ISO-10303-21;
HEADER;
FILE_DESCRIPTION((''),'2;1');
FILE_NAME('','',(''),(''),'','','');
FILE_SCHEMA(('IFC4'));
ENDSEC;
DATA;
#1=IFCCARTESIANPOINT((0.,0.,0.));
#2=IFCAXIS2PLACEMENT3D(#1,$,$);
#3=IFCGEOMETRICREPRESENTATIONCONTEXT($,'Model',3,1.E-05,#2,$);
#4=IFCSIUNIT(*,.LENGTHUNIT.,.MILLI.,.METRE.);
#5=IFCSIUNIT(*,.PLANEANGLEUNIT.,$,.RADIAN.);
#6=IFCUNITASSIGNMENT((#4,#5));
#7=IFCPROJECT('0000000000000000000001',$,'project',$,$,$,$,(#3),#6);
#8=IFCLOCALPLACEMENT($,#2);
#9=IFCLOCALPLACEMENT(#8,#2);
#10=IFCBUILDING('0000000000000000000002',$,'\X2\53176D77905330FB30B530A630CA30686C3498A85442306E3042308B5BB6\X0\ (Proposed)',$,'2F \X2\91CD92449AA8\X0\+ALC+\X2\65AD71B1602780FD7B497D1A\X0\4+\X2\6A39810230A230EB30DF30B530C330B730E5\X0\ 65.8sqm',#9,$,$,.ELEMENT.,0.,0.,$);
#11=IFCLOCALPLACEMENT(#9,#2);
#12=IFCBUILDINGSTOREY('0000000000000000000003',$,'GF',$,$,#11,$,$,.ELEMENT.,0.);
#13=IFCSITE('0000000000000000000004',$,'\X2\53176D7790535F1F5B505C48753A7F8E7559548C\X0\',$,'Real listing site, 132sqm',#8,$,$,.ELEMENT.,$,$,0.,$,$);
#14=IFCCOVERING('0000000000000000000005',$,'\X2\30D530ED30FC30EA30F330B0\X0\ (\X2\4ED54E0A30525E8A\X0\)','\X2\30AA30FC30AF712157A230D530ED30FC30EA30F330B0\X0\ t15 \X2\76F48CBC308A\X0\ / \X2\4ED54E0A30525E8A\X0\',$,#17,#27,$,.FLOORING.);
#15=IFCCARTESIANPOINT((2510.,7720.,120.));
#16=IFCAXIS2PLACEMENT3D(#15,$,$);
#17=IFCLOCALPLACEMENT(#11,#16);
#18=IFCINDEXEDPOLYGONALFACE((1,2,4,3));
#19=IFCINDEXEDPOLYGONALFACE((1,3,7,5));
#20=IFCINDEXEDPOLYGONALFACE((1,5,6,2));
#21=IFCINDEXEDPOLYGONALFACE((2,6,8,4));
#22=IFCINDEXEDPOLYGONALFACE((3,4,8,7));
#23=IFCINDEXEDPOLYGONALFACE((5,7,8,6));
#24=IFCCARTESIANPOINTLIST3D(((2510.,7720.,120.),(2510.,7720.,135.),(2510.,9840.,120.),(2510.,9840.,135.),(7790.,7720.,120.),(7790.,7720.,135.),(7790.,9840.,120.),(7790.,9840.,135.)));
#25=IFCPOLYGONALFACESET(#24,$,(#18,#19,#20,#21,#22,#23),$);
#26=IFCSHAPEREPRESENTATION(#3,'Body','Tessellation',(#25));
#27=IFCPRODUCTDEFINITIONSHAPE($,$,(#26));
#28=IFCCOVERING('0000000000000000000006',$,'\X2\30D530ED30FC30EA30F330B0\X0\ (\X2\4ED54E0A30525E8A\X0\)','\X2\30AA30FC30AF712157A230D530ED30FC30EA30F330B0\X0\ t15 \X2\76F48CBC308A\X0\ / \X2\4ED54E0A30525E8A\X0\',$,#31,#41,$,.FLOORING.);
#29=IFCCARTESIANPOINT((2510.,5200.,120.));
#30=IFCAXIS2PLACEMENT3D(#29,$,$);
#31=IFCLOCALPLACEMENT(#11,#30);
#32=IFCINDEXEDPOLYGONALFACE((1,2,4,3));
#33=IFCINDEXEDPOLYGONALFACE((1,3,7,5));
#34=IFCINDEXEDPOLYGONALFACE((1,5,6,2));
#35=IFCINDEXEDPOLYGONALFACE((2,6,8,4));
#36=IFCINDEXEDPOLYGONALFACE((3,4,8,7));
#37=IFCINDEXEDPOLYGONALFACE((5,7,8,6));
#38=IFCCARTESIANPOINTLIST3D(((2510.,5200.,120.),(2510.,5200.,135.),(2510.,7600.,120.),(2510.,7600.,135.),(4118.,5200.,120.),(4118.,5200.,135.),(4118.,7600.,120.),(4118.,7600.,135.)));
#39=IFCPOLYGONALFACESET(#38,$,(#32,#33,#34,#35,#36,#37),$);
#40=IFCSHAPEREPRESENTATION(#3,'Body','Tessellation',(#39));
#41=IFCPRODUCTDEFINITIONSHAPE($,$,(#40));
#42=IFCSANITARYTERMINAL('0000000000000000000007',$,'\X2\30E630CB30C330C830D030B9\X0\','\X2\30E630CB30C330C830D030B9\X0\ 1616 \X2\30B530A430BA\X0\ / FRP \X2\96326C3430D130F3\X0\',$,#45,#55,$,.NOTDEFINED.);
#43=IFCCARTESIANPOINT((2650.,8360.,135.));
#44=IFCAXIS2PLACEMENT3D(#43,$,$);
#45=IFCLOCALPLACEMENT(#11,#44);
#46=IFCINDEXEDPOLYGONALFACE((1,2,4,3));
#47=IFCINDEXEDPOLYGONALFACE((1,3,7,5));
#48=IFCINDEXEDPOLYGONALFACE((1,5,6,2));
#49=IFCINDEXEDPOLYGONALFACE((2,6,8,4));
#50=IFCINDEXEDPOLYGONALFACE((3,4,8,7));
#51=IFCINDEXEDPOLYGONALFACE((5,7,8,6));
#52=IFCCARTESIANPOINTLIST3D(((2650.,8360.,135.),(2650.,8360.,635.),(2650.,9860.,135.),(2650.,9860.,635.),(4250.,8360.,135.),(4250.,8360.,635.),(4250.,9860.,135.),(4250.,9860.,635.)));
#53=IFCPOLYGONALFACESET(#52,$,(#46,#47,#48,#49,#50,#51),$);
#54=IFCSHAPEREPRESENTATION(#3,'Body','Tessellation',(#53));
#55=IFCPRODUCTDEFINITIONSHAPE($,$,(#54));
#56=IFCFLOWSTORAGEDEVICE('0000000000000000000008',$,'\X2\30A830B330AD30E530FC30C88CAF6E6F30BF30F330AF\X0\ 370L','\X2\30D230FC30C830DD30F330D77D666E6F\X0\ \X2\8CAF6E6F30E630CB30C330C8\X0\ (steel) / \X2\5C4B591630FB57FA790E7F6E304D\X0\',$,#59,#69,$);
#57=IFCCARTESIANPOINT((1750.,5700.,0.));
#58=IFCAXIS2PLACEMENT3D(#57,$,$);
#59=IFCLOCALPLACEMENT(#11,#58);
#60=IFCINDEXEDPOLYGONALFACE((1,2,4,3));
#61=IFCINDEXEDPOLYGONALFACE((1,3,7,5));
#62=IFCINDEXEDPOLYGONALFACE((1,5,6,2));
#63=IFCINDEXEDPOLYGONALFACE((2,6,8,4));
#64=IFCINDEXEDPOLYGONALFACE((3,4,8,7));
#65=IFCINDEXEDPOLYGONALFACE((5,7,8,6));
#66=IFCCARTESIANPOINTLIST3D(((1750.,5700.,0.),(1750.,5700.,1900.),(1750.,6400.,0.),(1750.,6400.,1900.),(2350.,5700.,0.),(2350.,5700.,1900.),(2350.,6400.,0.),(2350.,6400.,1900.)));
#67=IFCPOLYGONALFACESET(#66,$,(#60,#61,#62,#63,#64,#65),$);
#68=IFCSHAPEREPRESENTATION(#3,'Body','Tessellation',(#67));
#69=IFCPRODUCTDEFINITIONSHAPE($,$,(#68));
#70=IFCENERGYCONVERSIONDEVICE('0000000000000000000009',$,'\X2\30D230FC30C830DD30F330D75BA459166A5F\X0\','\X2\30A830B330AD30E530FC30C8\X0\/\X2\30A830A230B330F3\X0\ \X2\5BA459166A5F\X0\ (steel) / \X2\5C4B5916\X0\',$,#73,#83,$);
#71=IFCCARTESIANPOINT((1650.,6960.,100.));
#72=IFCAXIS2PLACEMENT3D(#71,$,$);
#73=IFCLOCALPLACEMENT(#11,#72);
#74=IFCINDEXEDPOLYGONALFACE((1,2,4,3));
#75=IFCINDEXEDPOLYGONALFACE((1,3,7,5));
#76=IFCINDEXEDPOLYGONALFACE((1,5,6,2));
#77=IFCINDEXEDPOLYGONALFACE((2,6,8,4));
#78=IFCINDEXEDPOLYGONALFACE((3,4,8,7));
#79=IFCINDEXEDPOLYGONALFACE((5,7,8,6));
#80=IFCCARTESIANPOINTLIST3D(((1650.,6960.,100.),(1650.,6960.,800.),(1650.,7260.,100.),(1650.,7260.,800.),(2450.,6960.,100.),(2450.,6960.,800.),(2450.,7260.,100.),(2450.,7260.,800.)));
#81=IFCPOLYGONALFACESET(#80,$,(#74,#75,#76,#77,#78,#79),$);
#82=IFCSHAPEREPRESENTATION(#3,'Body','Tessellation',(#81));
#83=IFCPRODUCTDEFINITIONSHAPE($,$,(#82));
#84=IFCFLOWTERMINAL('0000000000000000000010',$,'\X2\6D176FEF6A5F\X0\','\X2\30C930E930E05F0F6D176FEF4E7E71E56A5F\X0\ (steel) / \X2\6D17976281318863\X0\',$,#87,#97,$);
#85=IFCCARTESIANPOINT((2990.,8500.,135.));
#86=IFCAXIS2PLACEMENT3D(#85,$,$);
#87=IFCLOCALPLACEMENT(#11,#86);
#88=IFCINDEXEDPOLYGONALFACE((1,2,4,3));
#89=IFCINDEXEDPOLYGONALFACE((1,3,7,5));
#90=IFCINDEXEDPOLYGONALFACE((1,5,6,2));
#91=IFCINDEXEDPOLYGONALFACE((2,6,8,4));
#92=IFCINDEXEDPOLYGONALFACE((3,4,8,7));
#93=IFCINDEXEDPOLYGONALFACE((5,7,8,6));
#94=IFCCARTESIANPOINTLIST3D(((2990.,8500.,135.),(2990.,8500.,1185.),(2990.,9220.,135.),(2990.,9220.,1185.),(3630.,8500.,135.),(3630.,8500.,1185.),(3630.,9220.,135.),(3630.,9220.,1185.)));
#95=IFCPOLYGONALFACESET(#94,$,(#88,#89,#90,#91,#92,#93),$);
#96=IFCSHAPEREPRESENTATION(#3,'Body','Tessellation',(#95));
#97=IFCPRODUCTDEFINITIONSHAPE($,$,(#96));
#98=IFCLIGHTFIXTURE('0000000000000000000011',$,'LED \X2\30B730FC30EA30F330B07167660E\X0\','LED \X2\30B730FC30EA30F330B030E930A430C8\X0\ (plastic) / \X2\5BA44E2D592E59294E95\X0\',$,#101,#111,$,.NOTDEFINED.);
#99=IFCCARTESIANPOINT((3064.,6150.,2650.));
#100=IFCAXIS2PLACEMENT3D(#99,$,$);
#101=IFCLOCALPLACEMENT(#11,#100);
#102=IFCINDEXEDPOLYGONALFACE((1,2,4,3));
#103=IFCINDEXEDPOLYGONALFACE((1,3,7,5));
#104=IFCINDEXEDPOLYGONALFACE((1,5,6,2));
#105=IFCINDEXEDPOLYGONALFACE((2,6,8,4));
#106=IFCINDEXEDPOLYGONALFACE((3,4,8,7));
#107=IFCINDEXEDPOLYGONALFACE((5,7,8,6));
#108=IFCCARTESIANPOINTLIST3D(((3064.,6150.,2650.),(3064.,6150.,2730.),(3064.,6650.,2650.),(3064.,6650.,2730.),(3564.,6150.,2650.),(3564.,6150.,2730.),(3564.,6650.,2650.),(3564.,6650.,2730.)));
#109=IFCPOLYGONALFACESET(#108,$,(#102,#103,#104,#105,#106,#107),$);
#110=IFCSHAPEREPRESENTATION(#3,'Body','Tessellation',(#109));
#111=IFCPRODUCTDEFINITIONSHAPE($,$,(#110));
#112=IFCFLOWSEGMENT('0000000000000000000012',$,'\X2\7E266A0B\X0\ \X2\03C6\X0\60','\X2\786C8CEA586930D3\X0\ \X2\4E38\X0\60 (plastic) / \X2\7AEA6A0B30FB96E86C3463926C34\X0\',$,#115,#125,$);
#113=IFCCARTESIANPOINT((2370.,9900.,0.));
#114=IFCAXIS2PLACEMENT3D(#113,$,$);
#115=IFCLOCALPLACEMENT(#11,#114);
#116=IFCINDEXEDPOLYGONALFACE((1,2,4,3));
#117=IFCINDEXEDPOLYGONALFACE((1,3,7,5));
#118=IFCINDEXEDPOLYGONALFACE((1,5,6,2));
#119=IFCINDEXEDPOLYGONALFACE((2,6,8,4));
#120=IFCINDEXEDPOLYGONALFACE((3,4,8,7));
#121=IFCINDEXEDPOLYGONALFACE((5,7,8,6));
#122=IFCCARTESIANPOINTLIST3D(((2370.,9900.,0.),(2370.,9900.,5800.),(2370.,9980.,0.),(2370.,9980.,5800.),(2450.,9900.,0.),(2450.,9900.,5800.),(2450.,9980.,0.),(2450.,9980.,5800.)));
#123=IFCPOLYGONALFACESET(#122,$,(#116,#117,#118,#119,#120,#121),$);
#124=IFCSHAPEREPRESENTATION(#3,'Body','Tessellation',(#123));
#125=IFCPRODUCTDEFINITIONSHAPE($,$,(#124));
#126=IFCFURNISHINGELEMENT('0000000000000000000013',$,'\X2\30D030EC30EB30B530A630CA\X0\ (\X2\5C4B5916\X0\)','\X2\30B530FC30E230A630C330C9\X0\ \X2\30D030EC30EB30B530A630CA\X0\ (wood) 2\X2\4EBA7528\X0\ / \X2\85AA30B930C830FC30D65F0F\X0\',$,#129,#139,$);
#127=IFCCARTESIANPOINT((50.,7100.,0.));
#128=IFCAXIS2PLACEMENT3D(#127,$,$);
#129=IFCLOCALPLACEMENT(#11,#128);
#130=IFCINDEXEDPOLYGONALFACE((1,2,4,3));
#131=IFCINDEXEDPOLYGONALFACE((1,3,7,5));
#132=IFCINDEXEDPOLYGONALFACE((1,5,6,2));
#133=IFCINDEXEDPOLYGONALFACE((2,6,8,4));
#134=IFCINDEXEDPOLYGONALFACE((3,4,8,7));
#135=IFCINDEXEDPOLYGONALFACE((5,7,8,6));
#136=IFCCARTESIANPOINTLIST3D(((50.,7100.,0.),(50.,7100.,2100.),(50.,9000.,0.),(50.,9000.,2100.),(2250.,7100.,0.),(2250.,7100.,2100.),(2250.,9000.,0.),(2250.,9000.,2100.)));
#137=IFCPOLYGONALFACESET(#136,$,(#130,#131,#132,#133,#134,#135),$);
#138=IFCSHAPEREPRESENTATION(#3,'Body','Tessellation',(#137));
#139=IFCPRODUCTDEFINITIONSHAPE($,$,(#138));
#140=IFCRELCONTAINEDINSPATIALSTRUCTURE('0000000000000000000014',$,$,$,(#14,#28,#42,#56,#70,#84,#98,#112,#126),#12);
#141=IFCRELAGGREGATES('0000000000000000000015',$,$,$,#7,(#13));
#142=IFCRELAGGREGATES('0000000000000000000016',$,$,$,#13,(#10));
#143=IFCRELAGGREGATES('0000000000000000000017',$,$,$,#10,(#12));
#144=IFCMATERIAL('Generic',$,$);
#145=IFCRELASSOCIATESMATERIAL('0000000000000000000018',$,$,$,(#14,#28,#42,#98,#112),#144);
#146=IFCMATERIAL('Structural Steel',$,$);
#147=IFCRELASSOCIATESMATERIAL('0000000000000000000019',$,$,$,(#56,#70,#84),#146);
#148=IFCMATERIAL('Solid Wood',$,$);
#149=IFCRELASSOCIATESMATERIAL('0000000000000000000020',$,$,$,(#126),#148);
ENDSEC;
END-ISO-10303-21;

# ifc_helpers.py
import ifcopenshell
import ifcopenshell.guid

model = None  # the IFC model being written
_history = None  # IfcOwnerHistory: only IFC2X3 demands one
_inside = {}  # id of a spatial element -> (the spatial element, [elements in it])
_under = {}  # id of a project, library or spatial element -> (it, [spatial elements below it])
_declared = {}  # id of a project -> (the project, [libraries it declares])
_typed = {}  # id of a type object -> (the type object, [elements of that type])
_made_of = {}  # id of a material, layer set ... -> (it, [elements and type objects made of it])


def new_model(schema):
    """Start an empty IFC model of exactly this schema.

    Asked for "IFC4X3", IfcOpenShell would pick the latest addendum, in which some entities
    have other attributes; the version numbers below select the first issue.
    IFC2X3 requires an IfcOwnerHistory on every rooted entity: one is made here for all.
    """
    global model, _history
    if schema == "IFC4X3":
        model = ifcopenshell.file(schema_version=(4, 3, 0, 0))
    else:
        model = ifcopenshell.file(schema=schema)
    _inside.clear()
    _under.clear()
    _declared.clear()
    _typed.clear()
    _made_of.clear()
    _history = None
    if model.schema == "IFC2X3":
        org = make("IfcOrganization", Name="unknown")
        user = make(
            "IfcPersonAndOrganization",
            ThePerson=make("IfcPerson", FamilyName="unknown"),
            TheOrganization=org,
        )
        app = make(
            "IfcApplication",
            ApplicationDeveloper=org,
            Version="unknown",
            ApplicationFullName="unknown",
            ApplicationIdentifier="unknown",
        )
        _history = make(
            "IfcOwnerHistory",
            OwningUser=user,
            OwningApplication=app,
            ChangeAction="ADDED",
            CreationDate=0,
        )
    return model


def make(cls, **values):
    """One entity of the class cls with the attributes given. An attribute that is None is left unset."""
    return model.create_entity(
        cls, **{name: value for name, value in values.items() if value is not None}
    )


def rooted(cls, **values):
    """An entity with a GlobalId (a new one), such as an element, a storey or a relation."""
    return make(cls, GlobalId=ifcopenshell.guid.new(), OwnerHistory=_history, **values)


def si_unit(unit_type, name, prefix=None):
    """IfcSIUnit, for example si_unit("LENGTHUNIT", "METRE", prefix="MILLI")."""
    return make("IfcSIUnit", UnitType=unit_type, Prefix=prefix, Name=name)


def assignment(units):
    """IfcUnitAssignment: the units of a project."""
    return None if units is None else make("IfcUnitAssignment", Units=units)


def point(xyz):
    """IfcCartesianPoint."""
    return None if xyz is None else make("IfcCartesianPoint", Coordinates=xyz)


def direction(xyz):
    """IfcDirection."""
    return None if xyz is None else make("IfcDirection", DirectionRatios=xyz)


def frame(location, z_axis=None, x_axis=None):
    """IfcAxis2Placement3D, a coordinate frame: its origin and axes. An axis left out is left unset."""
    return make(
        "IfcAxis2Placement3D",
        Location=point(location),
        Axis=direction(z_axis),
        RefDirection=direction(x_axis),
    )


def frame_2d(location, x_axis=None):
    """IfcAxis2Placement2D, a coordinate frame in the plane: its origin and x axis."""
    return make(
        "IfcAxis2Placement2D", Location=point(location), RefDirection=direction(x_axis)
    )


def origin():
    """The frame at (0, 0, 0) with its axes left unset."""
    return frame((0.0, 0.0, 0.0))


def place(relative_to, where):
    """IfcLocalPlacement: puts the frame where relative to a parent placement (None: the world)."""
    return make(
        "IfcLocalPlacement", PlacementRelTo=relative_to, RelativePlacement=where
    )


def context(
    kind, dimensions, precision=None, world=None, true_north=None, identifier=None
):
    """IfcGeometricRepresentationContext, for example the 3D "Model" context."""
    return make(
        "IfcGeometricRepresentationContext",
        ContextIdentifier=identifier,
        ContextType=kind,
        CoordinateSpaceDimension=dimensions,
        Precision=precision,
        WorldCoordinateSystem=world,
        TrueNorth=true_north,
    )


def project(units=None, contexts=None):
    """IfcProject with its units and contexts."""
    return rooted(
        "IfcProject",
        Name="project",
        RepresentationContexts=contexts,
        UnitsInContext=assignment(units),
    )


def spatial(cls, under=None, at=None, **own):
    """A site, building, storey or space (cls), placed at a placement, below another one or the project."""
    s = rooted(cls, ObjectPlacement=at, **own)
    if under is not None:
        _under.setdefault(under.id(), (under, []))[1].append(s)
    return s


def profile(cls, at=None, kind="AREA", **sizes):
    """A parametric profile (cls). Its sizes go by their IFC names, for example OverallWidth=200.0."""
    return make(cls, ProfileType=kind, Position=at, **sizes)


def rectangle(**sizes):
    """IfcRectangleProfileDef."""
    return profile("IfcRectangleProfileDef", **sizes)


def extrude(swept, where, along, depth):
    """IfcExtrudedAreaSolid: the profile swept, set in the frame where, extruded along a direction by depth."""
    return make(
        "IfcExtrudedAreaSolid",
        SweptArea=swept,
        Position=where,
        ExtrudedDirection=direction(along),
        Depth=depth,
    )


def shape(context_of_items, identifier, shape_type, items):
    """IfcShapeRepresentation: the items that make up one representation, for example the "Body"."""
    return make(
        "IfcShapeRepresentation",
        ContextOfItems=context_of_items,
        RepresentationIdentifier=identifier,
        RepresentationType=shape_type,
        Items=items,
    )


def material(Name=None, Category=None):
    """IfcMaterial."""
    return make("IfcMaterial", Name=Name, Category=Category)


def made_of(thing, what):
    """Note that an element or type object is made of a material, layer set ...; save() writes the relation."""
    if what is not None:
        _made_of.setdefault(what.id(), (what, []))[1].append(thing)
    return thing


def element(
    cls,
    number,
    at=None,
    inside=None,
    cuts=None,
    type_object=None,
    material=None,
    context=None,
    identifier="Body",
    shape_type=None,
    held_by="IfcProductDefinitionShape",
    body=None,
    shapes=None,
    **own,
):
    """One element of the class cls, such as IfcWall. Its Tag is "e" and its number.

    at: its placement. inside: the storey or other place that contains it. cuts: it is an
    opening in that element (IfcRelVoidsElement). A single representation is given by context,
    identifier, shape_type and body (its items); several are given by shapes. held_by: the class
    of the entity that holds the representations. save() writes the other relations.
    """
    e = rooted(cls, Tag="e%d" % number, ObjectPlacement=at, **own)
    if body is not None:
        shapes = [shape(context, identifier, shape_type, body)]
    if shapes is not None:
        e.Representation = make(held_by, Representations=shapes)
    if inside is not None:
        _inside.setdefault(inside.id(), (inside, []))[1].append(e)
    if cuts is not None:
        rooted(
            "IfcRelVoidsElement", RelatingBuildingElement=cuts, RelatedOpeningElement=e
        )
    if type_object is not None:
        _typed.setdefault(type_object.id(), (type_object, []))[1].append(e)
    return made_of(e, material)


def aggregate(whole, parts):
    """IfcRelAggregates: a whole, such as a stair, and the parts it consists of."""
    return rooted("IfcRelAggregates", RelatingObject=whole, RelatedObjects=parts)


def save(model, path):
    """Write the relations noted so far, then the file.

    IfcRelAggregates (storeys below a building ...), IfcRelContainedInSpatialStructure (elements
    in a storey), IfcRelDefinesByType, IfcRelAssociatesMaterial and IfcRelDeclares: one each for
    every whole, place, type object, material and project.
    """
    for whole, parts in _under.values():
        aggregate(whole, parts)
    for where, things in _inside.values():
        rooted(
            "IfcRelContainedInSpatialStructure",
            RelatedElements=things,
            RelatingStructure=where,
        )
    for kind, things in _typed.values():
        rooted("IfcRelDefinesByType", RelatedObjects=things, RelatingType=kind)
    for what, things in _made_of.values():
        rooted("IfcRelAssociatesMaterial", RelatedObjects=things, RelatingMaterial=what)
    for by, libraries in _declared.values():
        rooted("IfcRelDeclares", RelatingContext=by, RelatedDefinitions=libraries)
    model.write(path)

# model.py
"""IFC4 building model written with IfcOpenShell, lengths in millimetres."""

from ifc_helpers import new_model, si_unit, frame, frame_2d, origin, place, context, project, spatial, rectangle, extrude, material, element, save


model = new_model("IFC4")

# Units and contexts
model_context = context("Model", 3, precision=1e-05, world=origin())
ifc_project = project(units=[si_unit("LENGTHUNIT", "METRE", prefix="MILLI"), si_unit("PLANEANGLEUNIT", "RADIAN")], contexts=[model_context])

# Site, building, storey
site_placement = place(None, origin())
site = spatial("IfcSite", under=ifc_project, at=site_placement, Name="北海道弟子屈町美留和", ObjectType="Real listing site, 132sqm", CompositionType="ELEMENT", RefElevation=0.0)
building_placement = place(site_placement, origin())
building = spatial("IfcBuilding", under=site, at=building_placement, Name="北海道・サウナと水風呂のある家 (Proposed)", ObjectType="2F 重鉄骨+ALC+断熱性能等級4+樹脂アルミサッシュ 65.8sqm", CompositionType="ELEMENT", ElevationOfRefHeight=0.0, ElevationOfTerrain=0.0)
storey_placement = place(building_placement, origin())
storey = spatial("IfcBuildingStorey", under=building, at=storey_placement, Name="GF", CompositionType="ELEMENT", Elevation=0.0)

# Shared definitions
ifc_material_1 = material(Name="Solid Wood")

# Coverings
ifc_material_2 = material(Name="Generic")
covering_1_placement = place(storey_placement, frame((2510.0, 7720.0, 120.0)))
element("IfcCovering", 1, at=covering_1_placement, inside=storey, material=ifc_material_2, Name="フローリング (仕上げ床)", Description="オーク無垢フローリング t15 直貼り / 仕上げ床", PredefinedType="FLOORING", context=model_context, shape_type="SweptSolid", body=[
    extrude(rectangle(XDim=5280.0, YDim=2120.0, at=frame_2d((2640.0, 1060.0))), frame((2510.0, 7720.0, 120.0)), (0.0, 0.0, 1.0), 15.0),
])
covering_2_placement = place(storey_placement, frame((2510.0, 5200.0, 120.0)))
element("IfcCovering", 2, at=covering_2_placement, inside=storey, material=ifc_material_2, Name="フローリング (仕上げ床)", Description="オーク無垢フローリング t15 直貼り / 仕上げ床", PredefinedType="FLOORING", context=model_context, shape_type="SweptSolid", body=[
    extrude(rectangle(XDim=1608.0, YDim=2400.0, at=frame_2d((804.0, 1200.0))), frame((2510.0, 5200.0, 120.0)), (0.0, 0.0, 1.0), 15.0),
])

# Sanitary terminal
sanitary_terminal_placement = place(storey_placement, frame((2650.0, 8360.0, 135.0)))
element("IfcSanitaryTerminal", 3, at=sanitary_terminal_placement, inside=storey, material=ifc_material_2, Name="ユニットバス", Description="ユニットバス 1616 サイズ / FRP 防水パン", PredefinedType="NOTDEFINED", context=model_context, shape_type="SweptSolid", body=[
    extrude(rectangle(XDim=1600.0, YDim=1500.0, at=frame_2d((800.0, 750.0))), frame((2650.0, 8360.0, 135.0)), (0.0, 0.0, 1.0), 500.0),
])

# Flow storage device
ifc_material_3 = material(Name="Structural Steel")
flow_storage_device_placement = place(storey_placement, frame((1750.0, 5700.0, 0.0)))
element("IfcFlowStorageDevice", 4, at=flow_storage_device_placement, inside=storey, material=ifc_material_3, Name="エコキュート貯湯タンク 370L", Description="ヒートポンプ給湯 貯湯ユニット (steel) / 屋外・基礎置き", context=model_context, shape_type="SweptSolid", body=[
    extrude(rectangle(XDim=600.0, YDim=700.0, at=frame_2d((300.0, 350.0))), frame((1750.0, 5700.0, 0.0)), (0.0, 0.0, 1.0), 1900.0),
])

# Energy conversion device
energy_conversion_device_placement = place(storey_placement, frame((1650.0, 6960.0, 100.0)))
element("IfcEnergyConversionDevice", 5, at=energy_conversion_device_placement, inside=storey, material=ifc_material_3, Name="ヒートポンプ室外機", Description="エコキュート/エアコン 室外機 (steel) / 屋外", context=model_context, shape_type="SweptSolid", body=[
    extrude(rectangle(XDim=800.0, YDim=300.0, at=frame_2d((400.0, 150.0))), frame((1650.0, 6960.0, 100.0)), (0.0, 0.0, 1.0), 700.0),
])

# Flow terminal
flow_terminal_placement = place(storey_placement, frame((2990.0, 8500.0, 135.0)))
element("IfcFlowTerminal", 6, at=flow_terminal_placement, inside=storey, material=ifc_material_3, Name="洗濯機", Description="ドラム式洗濯乾燥機 (steel) / 洗面脱衣", context=model_context, shape_type="SweptSolid", body=[
    extrude(rectangle(XDim=640.0, YDim=720.0, at=frame_2d((320.0, 360.0))), frame((2990.0, 8500.0, 135.0)), (0.0, 0.0, 1.0), 1050.0),
])

# Light fixture
light_fixture_placement = place(storey_placement, frame((3064.0, 6150.0, 2650.0)))
element("IfcLightFixture", 7, at=light_fixture_placement, inside=storey, material=ifc_material_2, Name="LED シーリング照明", Description="LED シーリングライト (plastic) / 室中央天井", PredefinedType="NOTDEFINED", context=model_context, shape_type="SweptSolid", body=[
    extrude(rectangle(XDim=500.0, YDim=500.0, at=frame_2d((250.0, 250.0))), frame((3064.0, 6150.0, 2650.0)), (0.0, 0.0, 1.0), 80.0),
])

# Flow segment
flow_segment_placement = place(storey_placement, frame((2370.0, 9900.0, 0.0)))
element("IfcFlowSegment", 8, at=flow_segment_placement, inside=storey, material=ifc_material_2, Name="縦樋 φ60", Description="硬質塩ビ 丸60 (plastic) / 竪樋・雨水排水", context=model_context, shape_type="SweptSolid", body=[
    extrude(rectangle(XDim=80.0, YDim=80.0, at=frame_2d((40.0, 40.0))), frame((2370.0, 9900.0, 0.0)), (0.0, 0.0, 1.0), 5800.0),
])

# Furnishing element
furnishing_placement = place(storey_placement, frame((50.0, 7100.0, 0.0)))
element("IfcFurnishingElement", 9, at=furnishing_placement, inside=storey, material=ifc_material_1, Name="バレルサウナ (屋外)", Description="サーモウッド バレルサウナ (wood) 2人用 / 薪ストーブ式", context=model_context, shape_type="SweptSolid", body=[
    extrude(rectangle(XDim=2200.0, YDim=1900.0, at=frame_2d((1100.0, 950.0))), frame((50.0, 7100.0, 0.0)), (0.0, 0.0, 1.0), 2100.0),
])

save(model, "model.ifc")
